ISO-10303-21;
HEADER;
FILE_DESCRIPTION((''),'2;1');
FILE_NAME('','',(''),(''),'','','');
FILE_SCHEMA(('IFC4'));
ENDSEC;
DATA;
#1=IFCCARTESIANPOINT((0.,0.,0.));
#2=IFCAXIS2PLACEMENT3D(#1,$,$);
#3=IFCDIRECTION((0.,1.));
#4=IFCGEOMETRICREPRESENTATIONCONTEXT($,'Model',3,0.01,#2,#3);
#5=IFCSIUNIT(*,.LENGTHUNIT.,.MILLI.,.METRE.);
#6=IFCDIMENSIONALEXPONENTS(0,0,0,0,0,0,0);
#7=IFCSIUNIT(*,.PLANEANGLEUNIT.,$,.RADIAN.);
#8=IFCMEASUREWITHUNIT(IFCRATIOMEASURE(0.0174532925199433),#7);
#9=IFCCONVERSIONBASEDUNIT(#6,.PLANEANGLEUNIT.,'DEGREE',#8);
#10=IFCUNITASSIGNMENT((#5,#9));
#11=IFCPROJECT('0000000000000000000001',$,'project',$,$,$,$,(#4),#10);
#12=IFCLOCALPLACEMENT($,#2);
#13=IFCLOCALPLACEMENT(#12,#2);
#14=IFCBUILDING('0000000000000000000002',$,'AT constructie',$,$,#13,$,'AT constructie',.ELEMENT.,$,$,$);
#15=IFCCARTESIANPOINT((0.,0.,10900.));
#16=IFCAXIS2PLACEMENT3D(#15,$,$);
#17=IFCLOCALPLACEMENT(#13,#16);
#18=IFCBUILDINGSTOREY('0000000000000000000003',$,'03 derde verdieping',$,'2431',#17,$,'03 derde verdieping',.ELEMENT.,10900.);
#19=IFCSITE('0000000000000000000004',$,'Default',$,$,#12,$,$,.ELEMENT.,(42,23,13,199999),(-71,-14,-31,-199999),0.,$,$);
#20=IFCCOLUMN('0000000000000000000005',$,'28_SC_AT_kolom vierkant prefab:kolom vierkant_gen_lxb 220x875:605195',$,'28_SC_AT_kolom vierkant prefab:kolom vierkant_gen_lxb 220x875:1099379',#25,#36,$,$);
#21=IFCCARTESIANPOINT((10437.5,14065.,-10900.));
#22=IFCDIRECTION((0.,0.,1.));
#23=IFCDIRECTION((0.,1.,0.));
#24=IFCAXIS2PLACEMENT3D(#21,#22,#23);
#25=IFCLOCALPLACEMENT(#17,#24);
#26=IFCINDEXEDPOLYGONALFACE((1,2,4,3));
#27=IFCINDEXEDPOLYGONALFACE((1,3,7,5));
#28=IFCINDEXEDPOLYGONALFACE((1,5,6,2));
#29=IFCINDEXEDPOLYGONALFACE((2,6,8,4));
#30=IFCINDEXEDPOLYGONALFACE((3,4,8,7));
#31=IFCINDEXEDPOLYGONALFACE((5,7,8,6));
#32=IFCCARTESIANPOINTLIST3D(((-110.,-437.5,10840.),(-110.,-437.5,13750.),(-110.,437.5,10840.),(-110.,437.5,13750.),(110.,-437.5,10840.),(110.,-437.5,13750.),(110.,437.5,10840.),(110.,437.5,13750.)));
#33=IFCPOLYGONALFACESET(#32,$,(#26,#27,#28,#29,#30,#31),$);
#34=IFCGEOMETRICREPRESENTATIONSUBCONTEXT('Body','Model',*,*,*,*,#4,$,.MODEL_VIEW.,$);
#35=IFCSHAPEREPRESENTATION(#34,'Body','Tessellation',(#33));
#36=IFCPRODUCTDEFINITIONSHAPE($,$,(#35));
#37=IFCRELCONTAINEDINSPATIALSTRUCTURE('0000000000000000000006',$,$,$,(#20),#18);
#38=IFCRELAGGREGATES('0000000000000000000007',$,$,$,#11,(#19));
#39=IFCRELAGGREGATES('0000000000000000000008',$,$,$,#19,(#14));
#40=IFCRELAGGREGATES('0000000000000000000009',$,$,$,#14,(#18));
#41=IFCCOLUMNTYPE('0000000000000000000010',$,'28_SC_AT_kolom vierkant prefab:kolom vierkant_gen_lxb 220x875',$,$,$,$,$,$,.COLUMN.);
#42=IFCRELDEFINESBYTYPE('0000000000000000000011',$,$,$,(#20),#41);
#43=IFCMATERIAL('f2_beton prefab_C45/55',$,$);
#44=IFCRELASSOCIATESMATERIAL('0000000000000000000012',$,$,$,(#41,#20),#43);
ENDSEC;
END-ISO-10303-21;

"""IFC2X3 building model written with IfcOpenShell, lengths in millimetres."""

from ifc_helpers import new_model, entity, si_unit, converted_unit, direction, frame, origin, origin_2d_with_axis, place, context, subcontext, project, spatial, rectangle, extrude, source, transform, mapped, material, type_object, type_shapes, element, save


model = new_model("IFC2X3")

# Units and contexts
model_context = context("Model", 3, precision=0.01, world=origin(), true_north=direction((0.0, 1.0)))
body_context = subcontext(model_context, "Body", "Model", "MODEL_VIEW")
ifc_project = project(units=[si_unit("LENGTHUNIT", "METRE", prefix="MILLI"), converted_unit("PLANEANGLEUNIT", "DEGREE", entity("IfcRatioMeasure", 0.0174532925199433), si_unit("PLANEANGLEUNIT", "RADIAN"), dimensions=[0, 0, 0, 0, 0, 0, 0])], contexts=[model_context])

# Site, building, storey
site_placement = place(None, origin())
site = spatial("IfcSite", under=ifc_project, at=site_placement, Name="Default", CompositionType="ELEMENT", RefLatitude=(42, 23, 13, 199999), RefLongitude=(-71, -14, -31, -199999), RefElevation=0.0)
building_placement = place(site_placement, origin())
building = spatial("IfcBuilding", under=site, at=building_placement, Name="AT constructie", LongName="AT constructie", CompositionType="ELEMENT")
storey_placement = place(building_placement, frame((0.0, 0.0, 10900.0)))
storey = spatial("IfcBuildingStorey", under=building, at=storey_placement, Name="03 derde verdieping", ObjectType="2431", LongName="03 derde verdieping", CompositionType="ELEMENT", Elevation=10900.0)

# Column
ifc_material = material(Name="f2_beton prefab_C45/55")
column_type = type_object("IfcColumnType", Name="28_SC_AT_kolom vierkant prefab:kolom vierkant_gen_lxb 220x875", PredefinedType="COLUMN", material=ifc_material)
shared_shape = source(origin(), body_context, "Body", "SweptSolid", [
    extrude(rectangle(XDim=220.0, YDim=875.0, at=origin_2d_with_axis()), frame((0.0, 0.0, 10840.0), z_axis=(0.0, 0.0, 1.0), x_axis=(-1.0, 0.0, 0.0)), (0.0, 0.0, 1.0), 2910.0),
])
type_shapes(column_type, [shared_shape])
column_placement = place(storey_placement, frame((10437.5, 14065.0, -10900.0), z_axis=(0.0, 0.0, 1.0), x_axis=(0.0, 1.0, 0.0)))
element("IfcColumn", 1, at=column_placement, inside=storey, type_object=column_type, material=ifc_material, Name="28_SC_AT_kolom vierkant prefab:kolom vierkant_gen_lxb 220x875:605195", ObjectType="28_SC_AT_kolom vierkant prefab:kolom vierkant_gen_lxb 220x875:1099379", context=body_context, shape_type="MappedRepresentation", body=[
    mapped(shared_shape, transform((0.0, 0.0, 0.0), scale=1.0)),
])

save(model, "model.ifc")
